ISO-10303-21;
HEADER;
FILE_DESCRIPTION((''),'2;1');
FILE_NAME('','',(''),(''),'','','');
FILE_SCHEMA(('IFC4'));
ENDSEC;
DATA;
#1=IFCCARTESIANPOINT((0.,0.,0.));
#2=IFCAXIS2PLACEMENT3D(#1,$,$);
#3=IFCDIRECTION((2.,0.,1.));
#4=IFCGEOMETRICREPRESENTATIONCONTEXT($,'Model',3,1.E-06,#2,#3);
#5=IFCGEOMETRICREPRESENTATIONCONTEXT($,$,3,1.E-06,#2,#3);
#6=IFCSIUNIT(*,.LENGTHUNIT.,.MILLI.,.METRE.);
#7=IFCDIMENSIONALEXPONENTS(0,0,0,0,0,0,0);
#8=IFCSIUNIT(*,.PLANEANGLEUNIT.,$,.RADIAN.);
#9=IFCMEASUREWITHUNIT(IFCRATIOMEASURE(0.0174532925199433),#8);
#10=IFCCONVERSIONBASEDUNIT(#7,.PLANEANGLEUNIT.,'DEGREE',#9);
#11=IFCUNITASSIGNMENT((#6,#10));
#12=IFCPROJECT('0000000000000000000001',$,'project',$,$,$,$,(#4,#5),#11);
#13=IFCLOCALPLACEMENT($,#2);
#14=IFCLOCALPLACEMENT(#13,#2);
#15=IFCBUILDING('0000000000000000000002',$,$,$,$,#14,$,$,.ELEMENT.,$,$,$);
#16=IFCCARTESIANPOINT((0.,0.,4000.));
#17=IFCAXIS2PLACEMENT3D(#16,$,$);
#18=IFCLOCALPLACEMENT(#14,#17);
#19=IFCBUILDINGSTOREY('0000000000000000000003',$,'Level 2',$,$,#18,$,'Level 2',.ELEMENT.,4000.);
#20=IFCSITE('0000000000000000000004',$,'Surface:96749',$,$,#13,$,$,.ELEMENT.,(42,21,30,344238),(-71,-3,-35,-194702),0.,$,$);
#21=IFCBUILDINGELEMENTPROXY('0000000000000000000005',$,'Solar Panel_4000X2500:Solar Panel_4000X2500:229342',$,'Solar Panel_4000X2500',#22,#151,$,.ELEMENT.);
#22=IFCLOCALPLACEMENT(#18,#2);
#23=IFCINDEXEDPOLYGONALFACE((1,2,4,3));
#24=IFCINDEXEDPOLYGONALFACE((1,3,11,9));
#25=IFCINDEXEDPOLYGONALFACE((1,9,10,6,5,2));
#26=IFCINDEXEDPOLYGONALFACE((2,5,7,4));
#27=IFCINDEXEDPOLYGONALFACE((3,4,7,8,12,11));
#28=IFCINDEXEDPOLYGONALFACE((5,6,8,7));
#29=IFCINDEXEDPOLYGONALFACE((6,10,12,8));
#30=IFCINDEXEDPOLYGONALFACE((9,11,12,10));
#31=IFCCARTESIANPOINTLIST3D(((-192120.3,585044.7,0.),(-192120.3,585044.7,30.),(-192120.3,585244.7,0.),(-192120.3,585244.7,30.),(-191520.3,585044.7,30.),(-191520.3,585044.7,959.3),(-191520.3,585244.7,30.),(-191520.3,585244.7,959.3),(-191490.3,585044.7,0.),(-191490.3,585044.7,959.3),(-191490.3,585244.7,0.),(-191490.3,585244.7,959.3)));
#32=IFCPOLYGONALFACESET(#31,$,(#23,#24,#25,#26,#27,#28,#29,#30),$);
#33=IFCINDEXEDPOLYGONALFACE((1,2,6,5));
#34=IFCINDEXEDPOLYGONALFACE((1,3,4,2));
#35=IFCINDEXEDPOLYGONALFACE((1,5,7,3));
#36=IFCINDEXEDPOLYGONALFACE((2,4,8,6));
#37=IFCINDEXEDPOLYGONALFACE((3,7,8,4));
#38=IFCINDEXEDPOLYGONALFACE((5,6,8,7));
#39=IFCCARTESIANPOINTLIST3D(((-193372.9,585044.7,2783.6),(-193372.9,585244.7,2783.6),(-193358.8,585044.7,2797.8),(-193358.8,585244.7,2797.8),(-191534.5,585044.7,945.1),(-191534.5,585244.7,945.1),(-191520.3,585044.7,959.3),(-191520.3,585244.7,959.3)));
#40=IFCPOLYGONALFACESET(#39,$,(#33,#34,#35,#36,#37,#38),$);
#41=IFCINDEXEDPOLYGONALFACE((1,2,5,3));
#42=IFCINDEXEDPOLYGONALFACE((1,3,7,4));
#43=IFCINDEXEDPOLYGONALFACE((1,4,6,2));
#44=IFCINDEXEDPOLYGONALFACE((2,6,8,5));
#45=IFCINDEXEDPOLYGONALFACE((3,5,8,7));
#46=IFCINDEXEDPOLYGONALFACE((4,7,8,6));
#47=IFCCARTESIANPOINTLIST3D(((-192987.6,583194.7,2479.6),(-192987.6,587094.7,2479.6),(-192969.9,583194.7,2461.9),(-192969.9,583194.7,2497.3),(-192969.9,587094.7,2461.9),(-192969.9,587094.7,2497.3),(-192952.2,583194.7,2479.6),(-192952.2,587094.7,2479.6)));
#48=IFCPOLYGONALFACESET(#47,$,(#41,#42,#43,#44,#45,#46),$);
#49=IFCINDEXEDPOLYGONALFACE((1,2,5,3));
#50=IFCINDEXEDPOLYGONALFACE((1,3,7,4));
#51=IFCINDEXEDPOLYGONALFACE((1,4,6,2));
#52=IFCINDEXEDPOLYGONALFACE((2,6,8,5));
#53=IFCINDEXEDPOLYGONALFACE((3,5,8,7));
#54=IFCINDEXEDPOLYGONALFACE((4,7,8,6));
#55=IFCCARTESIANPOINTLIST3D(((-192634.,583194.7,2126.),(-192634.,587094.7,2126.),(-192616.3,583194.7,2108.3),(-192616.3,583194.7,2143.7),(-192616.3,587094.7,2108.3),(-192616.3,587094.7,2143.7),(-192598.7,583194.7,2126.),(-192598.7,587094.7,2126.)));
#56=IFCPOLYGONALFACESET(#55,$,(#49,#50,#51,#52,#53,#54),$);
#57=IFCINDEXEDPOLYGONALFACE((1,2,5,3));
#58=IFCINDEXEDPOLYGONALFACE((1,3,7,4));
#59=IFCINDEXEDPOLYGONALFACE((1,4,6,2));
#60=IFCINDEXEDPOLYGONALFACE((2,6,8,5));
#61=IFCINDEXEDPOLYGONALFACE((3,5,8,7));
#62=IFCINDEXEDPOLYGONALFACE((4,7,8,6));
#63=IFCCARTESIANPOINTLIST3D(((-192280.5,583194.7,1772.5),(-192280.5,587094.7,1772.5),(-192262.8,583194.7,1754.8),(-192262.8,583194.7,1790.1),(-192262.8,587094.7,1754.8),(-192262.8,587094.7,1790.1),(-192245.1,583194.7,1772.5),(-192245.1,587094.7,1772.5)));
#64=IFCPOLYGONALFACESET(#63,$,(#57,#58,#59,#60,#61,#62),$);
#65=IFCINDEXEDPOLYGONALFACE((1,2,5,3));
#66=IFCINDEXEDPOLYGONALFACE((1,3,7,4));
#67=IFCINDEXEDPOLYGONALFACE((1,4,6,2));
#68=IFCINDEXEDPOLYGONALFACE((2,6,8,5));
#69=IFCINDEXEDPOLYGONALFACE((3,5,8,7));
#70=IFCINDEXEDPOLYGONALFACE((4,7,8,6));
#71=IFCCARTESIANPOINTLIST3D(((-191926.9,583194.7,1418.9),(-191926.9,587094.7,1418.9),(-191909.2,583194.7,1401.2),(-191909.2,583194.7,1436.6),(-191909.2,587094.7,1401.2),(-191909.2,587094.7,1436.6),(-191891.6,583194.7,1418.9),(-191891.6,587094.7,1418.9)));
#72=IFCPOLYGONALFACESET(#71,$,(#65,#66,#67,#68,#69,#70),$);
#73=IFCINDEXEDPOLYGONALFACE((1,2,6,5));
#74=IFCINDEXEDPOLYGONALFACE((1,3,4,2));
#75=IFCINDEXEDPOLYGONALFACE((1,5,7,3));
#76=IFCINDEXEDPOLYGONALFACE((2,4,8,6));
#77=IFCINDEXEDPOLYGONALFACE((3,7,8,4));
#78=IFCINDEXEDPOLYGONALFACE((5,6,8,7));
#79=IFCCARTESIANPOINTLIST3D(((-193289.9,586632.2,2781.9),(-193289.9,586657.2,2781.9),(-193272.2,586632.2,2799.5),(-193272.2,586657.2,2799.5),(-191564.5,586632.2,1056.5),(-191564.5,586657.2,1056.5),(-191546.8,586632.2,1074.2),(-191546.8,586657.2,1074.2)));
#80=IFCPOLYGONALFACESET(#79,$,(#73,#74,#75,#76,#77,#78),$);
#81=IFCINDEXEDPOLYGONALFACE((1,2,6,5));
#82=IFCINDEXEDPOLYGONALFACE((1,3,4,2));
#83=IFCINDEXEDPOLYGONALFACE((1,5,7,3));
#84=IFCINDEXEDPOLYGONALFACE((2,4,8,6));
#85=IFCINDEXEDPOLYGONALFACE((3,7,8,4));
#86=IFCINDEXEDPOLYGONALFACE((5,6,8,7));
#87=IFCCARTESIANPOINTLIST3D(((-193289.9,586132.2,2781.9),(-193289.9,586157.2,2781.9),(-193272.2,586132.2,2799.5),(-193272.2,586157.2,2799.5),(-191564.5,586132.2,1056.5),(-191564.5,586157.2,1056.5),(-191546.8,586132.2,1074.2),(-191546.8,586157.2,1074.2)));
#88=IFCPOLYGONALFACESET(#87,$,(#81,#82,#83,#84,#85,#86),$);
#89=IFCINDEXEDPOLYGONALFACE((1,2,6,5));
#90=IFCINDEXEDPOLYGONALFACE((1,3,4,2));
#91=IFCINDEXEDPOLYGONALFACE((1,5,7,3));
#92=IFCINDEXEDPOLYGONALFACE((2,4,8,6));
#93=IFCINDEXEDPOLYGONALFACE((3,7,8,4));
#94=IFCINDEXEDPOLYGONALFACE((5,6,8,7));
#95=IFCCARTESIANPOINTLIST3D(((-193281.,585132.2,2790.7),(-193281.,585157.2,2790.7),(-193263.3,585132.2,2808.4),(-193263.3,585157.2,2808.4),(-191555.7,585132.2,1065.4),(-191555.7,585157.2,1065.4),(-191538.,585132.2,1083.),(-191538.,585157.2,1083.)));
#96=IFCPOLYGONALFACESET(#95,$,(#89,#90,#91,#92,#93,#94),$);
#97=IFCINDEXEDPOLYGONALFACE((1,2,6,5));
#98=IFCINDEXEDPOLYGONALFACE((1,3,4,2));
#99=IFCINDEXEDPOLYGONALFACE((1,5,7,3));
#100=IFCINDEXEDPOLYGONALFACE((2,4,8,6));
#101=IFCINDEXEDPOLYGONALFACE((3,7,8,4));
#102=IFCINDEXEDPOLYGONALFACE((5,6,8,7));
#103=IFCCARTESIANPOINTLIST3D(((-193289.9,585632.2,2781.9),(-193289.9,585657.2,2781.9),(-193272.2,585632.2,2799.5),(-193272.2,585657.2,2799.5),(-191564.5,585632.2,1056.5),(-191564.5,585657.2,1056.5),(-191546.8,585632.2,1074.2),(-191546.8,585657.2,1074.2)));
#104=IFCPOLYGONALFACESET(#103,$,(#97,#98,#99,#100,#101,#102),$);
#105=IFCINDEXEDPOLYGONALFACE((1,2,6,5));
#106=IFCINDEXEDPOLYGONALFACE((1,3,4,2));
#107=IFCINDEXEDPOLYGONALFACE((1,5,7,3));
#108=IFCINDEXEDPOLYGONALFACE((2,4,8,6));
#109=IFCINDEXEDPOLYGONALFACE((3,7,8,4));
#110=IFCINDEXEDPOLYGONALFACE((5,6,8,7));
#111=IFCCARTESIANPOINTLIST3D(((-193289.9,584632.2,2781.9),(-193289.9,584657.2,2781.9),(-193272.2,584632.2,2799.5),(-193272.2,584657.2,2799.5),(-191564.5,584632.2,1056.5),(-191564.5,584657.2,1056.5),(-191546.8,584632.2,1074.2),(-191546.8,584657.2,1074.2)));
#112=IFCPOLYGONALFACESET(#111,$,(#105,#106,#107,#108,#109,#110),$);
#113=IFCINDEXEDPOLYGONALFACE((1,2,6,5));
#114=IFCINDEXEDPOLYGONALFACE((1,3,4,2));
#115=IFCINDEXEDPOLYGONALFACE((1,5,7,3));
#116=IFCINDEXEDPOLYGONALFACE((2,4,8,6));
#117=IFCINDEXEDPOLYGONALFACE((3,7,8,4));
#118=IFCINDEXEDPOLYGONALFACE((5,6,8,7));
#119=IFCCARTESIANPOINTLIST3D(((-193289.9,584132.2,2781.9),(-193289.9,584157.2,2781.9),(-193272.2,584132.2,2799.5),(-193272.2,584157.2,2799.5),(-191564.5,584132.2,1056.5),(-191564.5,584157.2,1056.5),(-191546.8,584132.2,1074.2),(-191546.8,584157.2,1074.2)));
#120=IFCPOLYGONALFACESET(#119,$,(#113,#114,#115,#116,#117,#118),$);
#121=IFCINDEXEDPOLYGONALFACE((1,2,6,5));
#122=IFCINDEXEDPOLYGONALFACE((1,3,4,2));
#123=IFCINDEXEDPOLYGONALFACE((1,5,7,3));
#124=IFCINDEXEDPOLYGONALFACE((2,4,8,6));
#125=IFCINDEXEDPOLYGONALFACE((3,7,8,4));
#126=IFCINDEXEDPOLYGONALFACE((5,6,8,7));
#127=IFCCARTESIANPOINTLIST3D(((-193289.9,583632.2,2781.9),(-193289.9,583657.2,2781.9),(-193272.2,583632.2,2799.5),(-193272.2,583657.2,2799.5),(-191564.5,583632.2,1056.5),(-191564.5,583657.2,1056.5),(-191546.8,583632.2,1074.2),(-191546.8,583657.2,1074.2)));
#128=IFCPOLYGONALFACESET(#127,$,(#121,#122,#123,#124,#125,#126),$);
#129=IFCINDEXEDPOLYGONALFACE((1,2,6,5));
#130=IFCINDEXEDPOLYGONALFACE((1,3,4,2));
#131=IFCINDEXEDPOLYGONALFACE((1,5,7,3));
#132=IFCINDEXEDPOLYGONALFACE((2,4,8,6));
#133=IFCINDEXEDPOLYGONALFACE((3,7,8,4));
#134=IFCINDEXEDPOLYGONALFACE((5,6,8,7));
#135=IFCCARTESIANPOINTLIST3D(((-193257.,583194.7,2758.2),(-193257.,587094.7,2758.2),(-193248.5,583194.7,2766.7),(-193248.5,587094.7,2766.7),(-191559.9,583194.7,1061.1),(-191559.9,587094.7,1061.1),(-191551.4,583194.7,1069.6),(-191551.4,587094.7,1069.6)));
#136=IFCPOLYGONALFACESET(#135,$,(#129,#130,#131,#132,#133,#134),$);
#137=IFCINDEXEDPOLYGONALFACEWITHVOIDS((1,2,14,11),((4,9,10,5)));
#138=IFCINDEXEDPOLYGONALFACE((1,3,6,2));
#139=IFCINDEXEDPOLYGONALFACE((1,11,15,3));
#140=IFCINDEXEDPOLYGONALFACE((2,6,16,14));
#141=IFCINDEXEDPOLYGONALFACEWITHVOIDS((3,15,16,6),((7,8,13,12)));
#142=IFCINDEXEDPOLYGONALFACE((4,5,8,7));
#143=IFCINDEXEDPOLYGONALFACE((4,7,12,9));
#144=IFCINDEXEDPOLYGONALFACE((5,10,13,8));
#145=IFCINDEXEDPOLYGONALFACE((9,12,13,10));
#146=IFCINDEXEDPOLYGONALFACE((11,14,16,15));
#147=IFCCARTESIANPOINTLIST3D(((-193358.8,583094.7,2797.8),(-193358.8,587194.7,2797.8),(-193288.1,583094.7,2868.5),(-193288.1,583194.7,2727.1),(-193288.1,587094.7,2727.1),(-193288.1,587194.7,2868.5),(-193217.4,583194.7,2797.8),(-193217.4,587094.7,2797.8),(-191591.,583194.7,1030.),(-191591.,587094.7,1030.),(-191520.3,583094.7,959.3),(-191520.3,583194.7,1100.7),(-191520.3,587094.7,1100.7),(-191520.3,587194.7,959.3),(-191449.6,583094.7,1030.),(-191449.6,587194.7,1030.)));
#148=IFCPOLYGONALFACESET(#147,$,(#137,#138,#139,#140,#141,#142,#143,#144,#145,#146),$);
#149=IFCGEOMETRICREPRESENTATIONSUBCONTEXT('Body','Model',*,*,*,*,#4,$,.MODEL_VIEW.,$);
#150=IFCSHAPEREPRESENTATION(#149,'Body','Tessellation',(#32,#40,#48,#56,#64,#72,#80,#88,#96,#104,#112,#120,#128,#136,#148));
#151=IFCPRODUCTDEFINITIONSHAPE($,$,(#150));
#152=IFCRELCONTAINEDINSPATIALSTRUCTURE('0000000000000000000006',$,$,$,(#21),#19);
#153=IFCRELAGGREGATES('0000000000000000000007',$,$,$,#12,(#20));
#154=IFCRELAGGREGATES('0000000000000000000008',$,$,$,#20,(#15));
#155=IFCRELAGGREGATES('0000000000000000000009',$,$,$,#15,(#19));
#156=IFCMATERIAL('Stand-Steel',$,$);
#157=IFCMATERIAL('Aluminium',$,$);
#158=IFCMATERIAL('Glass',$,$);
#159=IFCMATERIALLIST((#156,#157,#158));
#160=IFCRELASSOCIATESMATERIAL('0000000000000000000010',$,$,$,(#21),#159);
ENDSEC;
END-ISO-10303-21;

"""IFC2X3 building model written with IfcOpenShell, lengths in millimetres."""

from ifc_helpers import new_model, entity, si_unit, converted_unit, direction, frame, frame_2d, origin, origin_2d_with_axis, place, context, subcontext, project, spatial, polyline, rectangle, outline, extrude, source, transform, mapped, material, material_list, element, save


model = new_model("IFC2X3")

# Units and contexts
model_context = context("Model", 3, precision=1e-06, world=origin(), true_north=direction((2.0, 0.0, 1.0)))
context_of_model = context(None, 3, precision=1e-06, world=origin(), true_north=direction((2.0, 0.0, 1.0)))
body_context = subcontext(model_context, "Body", "Model", "MODEL_VIEW")
ifc_project = project(units=[si_unit("LENGTHUNIT", "METRE", prefix="MILLI"), converted_unit("PLANEANGLEUNIT", "DEGREE", entity("IfcRatioMeasure", 0.0174532925199433), si_unit("PLANEANGLEUNIT", "RADIAN"), dimensions=[0, 0, 0, 0, 0, 0, 0])], contexts=[model_context, context_of_model])

# Site, building, storey
site_placement = place(None, origin())
site = spatial("IfcSite", under=ifc_project, at=site_placement, Name="Surface:96749", CompositionType="ELEMENT", RefLatitude=(42, 21, 30, 344238), RefLongitude=(-71, -3, -35, -194702), RefElevation=0.0)
building_placement = place(site_placement, origin())
building = spatial("IfcBuilding", under=site, at=building_placement, CompositionType="ELEMENT")
storey_placement = place(building_placement, frame((0.0, 0.0, 4000.0)))
storey = spatial("IfcBuildingStorey", under=building, at=storey_placement, Name="Level 2", LongName="Level 2", CompositionType="ELEMENT", Elevation=4000.0)

# Building element proxy
ifc_material_1 = material(Name="Stand-Steel")
ifc_material_2 = material(Name="Aluminium")
ifc_material_3 = material(Name="Glass")
shared_shape = source(origin(), body_context, "Body", "SweptSolid", [
    extrude(outline(polyline([(-629.5, -220.0), (329.8, -220.0), (329.8, 410.0), (299.8, 410.0), (299.8, -190.0), (-629.5, -190.0), (-629.5, -220.0)])), frame((-190.0, -100.0, 299.8), z_axis=(0.0, 1.0, 0.0), x_axis=(0.0, 0.0, -1.0)), (0.0, 0.0, 1.0), 200.0),
    extrude(rectangle(XDim=20.0, YDim=200.0, at=frame_2d((0.0, 0.0), x_axis=(0.0, 1.0))), frame((-7.1, 0.0, 922.2), z_axis=(-0.707107, 0.0, 0.707107), x_axis=(0.0, 1.0, 0.0)), (0.0, 0.0, 1.0), 2600.0),
    extrude(rectangle(XDim=25.0, YDim=25.0, at=frame_2d((0.0, 0.0), x_axis=(1.0, 0.0))), frame((-1449.6, -1950.0, 2449.6), z_axis=(0.0, 1.0, 0.0), x_axis=(-0.707107, 0.0, -0.707107)), (0.0, 0.0, 1.0), 3900.0),
    extrude(rectangle(XDim=25.0, YDim=25.0, at=origin_2d_with_axis()), frame((-1096.0, -1950.0, 2096.0), z_axis=(0.0, 1.0, 0.0), x_axis=(-0.707107, 0.0, -0.707107)), (0.0, 0.0, 1.0), 3900.0),
    extrude(rectangle(XDim=25.0, YDim=25.0, at=origin_2d_with_axis()), frame((-742.5, -1950.0, 1742.5), z_axis=(0.0, 1.0, 0.0), x_axis=(-0.707107, 0.0, -0.707107)), (0.0, 0.0, 1.0), 3900.0),
    extrude(rectangle(XDim=25.0, YDim=25.0, at=frame_2d((0.0, 0.0), x_axis=(1.0, 0.0))), frame((-388.9, -1950.0, 1388.9), z_axis=(0.0, 1.0, 0.0), x_axis=(-0.707107, 0.0, -0.707107)), (0.0, 0.0, 1.0), 3900.0),
    extrude(rectangle(XDim=25.0, YDim=25.0, at=frame_2d((0.0, 0.0), x_axis=(0.0, 1.0))), frame((-35.4, 1500.0, 1035.4), z_axis=(-0.707107, 0.0, 0.707107), x_axis=(0.0, 1.0, 0.0)), (0.0, 0.0, 1.0), 2440.0),
    extrude(rectangle(XDim=25.0, YDim=25.0, at=frame_2d((0.0, 0.0), x_axis=(0.0, 1.0))), frame((-35.4, 1000.0, 1035.4), z_axis=(-0.707107, 0.0, 0.707107), x_axis=(0.0, 1.0, 0.0)), (0.0, 0.0, 1.0), 2440.0),
    extrude(rectangle(XDim=25.0, YDim=25.0, at=frame_2d((0.0, 0.0), x_axis=(0.0, 1.0))), frame((-26.5, 0.0, 1044.2), z_axis=(-0.707107, 0.0, 0.707107), x_axis=(0.0, -1.0, 0.0)), (0.0, 0.0, 1.0), 2440.0),
    extrude(rectangle(XDim=25.0, YDim=25.0, at=frame_2d((0.0, 0.0), x_axis=(0.0, 1.0))), frame((-35.4, 500.0, 1035.4), z_axis=(-0.707107, 0.0, 0.707107), x_axis=(0.0, 1.0, 0.0)), (0.0, 0.0, 1.0), 2440.0),
    extrude(rectangle(XDim=25.0, YDim=25.0, at=frame_2d((0.0, 0.0), x_axis=(0.0, 1.0))), frame((-35.4, -500.0, 1035.4), z_axis=(-0.707107, 0.0, 0.707107), x_axis=(0.0, 1.0, 0.0)), (0.0, 0.0, 1.0), 2440.0),
    extrude(rectangle(XDim=25.0, YDim=25.0, at=frame_2d((0.0, 0.0), x_axis=(0.0, 1.0))), frame((-35.4, -1000.0, 1035.4), z_axis=(-0.707107, 0.0, 0.707107), x_axis=(0.0, 1.0, 0.0)), (0.0, 0.0, 1.0), 2440.0),
    extrude(rectangle(XDim=25.0, YDim=25.0, at=frame_2d((0.0, 0.0), x_axis=(0.0, 1.0))), frame((-35.4, -1500.0, 1035.4), z_axis=(-0.707107, 0.0, 0.707107), x_axis=(0.0, 1.0, 0.0)), (0.0, 0.0, 1.0), 2440.0),
    extrude(rectangle(XDim=2400.0, YDim=12.0, at=frame_2d((0.0, 0.0), x_axis=(1.0, 0.0))), frame((-883.9, -1950.0, 1883.9), z_axis=(0.0, 1.0, 0.0), x_axis=(0.707107, 0.0, -0.707107)), (0.0, 0.0, 1.0), 3900.0),
    extrude(outline(polyline([(-2050.0, -1300.0), (2050.0, -1300.0), (2050.0, 1300.0), (-2050.0, 1300.0), (-2050.0, -1300.0)]), holes=[polyline([(1950.0, -1200.0), (-1950.0, -1200.0), (-1950.0, 1200.0), (1950.0, 1200.0), (1950.0, -1200.0)])]), frame((-919.2, 0.0, 1848.5), z_axis=(0.707107, 0.0, 0.707107), x_axis=(0.0, 1.0, 0.0)), (0.0, 0.0, 1.0), 100.0),
])
ifc_material_list_1 = material_list([ifc_material_1, ifc_material_2, ifc_material_3])
proxy_1_placement = place(storey_placement, frame((-191520.3, 585144.7, 30.0)))
element("IfcBuildingElementProxy", 1, at=proxy_1_placement, inside=storey, material=ifc_material_list_1, Name="Solar Panel_4000X2500:Solar Panel_4000X2500:229342", ObjectType="Solar Panel_4000X2500", CompositionType="ELEMENT", context=body_context, shape_type="MappedRepresentation", body=[
    mapped(shared_shape, transform((0.0, 0.0, 0.0), scale=1.0)),
])

save(model, "model.ifc")
